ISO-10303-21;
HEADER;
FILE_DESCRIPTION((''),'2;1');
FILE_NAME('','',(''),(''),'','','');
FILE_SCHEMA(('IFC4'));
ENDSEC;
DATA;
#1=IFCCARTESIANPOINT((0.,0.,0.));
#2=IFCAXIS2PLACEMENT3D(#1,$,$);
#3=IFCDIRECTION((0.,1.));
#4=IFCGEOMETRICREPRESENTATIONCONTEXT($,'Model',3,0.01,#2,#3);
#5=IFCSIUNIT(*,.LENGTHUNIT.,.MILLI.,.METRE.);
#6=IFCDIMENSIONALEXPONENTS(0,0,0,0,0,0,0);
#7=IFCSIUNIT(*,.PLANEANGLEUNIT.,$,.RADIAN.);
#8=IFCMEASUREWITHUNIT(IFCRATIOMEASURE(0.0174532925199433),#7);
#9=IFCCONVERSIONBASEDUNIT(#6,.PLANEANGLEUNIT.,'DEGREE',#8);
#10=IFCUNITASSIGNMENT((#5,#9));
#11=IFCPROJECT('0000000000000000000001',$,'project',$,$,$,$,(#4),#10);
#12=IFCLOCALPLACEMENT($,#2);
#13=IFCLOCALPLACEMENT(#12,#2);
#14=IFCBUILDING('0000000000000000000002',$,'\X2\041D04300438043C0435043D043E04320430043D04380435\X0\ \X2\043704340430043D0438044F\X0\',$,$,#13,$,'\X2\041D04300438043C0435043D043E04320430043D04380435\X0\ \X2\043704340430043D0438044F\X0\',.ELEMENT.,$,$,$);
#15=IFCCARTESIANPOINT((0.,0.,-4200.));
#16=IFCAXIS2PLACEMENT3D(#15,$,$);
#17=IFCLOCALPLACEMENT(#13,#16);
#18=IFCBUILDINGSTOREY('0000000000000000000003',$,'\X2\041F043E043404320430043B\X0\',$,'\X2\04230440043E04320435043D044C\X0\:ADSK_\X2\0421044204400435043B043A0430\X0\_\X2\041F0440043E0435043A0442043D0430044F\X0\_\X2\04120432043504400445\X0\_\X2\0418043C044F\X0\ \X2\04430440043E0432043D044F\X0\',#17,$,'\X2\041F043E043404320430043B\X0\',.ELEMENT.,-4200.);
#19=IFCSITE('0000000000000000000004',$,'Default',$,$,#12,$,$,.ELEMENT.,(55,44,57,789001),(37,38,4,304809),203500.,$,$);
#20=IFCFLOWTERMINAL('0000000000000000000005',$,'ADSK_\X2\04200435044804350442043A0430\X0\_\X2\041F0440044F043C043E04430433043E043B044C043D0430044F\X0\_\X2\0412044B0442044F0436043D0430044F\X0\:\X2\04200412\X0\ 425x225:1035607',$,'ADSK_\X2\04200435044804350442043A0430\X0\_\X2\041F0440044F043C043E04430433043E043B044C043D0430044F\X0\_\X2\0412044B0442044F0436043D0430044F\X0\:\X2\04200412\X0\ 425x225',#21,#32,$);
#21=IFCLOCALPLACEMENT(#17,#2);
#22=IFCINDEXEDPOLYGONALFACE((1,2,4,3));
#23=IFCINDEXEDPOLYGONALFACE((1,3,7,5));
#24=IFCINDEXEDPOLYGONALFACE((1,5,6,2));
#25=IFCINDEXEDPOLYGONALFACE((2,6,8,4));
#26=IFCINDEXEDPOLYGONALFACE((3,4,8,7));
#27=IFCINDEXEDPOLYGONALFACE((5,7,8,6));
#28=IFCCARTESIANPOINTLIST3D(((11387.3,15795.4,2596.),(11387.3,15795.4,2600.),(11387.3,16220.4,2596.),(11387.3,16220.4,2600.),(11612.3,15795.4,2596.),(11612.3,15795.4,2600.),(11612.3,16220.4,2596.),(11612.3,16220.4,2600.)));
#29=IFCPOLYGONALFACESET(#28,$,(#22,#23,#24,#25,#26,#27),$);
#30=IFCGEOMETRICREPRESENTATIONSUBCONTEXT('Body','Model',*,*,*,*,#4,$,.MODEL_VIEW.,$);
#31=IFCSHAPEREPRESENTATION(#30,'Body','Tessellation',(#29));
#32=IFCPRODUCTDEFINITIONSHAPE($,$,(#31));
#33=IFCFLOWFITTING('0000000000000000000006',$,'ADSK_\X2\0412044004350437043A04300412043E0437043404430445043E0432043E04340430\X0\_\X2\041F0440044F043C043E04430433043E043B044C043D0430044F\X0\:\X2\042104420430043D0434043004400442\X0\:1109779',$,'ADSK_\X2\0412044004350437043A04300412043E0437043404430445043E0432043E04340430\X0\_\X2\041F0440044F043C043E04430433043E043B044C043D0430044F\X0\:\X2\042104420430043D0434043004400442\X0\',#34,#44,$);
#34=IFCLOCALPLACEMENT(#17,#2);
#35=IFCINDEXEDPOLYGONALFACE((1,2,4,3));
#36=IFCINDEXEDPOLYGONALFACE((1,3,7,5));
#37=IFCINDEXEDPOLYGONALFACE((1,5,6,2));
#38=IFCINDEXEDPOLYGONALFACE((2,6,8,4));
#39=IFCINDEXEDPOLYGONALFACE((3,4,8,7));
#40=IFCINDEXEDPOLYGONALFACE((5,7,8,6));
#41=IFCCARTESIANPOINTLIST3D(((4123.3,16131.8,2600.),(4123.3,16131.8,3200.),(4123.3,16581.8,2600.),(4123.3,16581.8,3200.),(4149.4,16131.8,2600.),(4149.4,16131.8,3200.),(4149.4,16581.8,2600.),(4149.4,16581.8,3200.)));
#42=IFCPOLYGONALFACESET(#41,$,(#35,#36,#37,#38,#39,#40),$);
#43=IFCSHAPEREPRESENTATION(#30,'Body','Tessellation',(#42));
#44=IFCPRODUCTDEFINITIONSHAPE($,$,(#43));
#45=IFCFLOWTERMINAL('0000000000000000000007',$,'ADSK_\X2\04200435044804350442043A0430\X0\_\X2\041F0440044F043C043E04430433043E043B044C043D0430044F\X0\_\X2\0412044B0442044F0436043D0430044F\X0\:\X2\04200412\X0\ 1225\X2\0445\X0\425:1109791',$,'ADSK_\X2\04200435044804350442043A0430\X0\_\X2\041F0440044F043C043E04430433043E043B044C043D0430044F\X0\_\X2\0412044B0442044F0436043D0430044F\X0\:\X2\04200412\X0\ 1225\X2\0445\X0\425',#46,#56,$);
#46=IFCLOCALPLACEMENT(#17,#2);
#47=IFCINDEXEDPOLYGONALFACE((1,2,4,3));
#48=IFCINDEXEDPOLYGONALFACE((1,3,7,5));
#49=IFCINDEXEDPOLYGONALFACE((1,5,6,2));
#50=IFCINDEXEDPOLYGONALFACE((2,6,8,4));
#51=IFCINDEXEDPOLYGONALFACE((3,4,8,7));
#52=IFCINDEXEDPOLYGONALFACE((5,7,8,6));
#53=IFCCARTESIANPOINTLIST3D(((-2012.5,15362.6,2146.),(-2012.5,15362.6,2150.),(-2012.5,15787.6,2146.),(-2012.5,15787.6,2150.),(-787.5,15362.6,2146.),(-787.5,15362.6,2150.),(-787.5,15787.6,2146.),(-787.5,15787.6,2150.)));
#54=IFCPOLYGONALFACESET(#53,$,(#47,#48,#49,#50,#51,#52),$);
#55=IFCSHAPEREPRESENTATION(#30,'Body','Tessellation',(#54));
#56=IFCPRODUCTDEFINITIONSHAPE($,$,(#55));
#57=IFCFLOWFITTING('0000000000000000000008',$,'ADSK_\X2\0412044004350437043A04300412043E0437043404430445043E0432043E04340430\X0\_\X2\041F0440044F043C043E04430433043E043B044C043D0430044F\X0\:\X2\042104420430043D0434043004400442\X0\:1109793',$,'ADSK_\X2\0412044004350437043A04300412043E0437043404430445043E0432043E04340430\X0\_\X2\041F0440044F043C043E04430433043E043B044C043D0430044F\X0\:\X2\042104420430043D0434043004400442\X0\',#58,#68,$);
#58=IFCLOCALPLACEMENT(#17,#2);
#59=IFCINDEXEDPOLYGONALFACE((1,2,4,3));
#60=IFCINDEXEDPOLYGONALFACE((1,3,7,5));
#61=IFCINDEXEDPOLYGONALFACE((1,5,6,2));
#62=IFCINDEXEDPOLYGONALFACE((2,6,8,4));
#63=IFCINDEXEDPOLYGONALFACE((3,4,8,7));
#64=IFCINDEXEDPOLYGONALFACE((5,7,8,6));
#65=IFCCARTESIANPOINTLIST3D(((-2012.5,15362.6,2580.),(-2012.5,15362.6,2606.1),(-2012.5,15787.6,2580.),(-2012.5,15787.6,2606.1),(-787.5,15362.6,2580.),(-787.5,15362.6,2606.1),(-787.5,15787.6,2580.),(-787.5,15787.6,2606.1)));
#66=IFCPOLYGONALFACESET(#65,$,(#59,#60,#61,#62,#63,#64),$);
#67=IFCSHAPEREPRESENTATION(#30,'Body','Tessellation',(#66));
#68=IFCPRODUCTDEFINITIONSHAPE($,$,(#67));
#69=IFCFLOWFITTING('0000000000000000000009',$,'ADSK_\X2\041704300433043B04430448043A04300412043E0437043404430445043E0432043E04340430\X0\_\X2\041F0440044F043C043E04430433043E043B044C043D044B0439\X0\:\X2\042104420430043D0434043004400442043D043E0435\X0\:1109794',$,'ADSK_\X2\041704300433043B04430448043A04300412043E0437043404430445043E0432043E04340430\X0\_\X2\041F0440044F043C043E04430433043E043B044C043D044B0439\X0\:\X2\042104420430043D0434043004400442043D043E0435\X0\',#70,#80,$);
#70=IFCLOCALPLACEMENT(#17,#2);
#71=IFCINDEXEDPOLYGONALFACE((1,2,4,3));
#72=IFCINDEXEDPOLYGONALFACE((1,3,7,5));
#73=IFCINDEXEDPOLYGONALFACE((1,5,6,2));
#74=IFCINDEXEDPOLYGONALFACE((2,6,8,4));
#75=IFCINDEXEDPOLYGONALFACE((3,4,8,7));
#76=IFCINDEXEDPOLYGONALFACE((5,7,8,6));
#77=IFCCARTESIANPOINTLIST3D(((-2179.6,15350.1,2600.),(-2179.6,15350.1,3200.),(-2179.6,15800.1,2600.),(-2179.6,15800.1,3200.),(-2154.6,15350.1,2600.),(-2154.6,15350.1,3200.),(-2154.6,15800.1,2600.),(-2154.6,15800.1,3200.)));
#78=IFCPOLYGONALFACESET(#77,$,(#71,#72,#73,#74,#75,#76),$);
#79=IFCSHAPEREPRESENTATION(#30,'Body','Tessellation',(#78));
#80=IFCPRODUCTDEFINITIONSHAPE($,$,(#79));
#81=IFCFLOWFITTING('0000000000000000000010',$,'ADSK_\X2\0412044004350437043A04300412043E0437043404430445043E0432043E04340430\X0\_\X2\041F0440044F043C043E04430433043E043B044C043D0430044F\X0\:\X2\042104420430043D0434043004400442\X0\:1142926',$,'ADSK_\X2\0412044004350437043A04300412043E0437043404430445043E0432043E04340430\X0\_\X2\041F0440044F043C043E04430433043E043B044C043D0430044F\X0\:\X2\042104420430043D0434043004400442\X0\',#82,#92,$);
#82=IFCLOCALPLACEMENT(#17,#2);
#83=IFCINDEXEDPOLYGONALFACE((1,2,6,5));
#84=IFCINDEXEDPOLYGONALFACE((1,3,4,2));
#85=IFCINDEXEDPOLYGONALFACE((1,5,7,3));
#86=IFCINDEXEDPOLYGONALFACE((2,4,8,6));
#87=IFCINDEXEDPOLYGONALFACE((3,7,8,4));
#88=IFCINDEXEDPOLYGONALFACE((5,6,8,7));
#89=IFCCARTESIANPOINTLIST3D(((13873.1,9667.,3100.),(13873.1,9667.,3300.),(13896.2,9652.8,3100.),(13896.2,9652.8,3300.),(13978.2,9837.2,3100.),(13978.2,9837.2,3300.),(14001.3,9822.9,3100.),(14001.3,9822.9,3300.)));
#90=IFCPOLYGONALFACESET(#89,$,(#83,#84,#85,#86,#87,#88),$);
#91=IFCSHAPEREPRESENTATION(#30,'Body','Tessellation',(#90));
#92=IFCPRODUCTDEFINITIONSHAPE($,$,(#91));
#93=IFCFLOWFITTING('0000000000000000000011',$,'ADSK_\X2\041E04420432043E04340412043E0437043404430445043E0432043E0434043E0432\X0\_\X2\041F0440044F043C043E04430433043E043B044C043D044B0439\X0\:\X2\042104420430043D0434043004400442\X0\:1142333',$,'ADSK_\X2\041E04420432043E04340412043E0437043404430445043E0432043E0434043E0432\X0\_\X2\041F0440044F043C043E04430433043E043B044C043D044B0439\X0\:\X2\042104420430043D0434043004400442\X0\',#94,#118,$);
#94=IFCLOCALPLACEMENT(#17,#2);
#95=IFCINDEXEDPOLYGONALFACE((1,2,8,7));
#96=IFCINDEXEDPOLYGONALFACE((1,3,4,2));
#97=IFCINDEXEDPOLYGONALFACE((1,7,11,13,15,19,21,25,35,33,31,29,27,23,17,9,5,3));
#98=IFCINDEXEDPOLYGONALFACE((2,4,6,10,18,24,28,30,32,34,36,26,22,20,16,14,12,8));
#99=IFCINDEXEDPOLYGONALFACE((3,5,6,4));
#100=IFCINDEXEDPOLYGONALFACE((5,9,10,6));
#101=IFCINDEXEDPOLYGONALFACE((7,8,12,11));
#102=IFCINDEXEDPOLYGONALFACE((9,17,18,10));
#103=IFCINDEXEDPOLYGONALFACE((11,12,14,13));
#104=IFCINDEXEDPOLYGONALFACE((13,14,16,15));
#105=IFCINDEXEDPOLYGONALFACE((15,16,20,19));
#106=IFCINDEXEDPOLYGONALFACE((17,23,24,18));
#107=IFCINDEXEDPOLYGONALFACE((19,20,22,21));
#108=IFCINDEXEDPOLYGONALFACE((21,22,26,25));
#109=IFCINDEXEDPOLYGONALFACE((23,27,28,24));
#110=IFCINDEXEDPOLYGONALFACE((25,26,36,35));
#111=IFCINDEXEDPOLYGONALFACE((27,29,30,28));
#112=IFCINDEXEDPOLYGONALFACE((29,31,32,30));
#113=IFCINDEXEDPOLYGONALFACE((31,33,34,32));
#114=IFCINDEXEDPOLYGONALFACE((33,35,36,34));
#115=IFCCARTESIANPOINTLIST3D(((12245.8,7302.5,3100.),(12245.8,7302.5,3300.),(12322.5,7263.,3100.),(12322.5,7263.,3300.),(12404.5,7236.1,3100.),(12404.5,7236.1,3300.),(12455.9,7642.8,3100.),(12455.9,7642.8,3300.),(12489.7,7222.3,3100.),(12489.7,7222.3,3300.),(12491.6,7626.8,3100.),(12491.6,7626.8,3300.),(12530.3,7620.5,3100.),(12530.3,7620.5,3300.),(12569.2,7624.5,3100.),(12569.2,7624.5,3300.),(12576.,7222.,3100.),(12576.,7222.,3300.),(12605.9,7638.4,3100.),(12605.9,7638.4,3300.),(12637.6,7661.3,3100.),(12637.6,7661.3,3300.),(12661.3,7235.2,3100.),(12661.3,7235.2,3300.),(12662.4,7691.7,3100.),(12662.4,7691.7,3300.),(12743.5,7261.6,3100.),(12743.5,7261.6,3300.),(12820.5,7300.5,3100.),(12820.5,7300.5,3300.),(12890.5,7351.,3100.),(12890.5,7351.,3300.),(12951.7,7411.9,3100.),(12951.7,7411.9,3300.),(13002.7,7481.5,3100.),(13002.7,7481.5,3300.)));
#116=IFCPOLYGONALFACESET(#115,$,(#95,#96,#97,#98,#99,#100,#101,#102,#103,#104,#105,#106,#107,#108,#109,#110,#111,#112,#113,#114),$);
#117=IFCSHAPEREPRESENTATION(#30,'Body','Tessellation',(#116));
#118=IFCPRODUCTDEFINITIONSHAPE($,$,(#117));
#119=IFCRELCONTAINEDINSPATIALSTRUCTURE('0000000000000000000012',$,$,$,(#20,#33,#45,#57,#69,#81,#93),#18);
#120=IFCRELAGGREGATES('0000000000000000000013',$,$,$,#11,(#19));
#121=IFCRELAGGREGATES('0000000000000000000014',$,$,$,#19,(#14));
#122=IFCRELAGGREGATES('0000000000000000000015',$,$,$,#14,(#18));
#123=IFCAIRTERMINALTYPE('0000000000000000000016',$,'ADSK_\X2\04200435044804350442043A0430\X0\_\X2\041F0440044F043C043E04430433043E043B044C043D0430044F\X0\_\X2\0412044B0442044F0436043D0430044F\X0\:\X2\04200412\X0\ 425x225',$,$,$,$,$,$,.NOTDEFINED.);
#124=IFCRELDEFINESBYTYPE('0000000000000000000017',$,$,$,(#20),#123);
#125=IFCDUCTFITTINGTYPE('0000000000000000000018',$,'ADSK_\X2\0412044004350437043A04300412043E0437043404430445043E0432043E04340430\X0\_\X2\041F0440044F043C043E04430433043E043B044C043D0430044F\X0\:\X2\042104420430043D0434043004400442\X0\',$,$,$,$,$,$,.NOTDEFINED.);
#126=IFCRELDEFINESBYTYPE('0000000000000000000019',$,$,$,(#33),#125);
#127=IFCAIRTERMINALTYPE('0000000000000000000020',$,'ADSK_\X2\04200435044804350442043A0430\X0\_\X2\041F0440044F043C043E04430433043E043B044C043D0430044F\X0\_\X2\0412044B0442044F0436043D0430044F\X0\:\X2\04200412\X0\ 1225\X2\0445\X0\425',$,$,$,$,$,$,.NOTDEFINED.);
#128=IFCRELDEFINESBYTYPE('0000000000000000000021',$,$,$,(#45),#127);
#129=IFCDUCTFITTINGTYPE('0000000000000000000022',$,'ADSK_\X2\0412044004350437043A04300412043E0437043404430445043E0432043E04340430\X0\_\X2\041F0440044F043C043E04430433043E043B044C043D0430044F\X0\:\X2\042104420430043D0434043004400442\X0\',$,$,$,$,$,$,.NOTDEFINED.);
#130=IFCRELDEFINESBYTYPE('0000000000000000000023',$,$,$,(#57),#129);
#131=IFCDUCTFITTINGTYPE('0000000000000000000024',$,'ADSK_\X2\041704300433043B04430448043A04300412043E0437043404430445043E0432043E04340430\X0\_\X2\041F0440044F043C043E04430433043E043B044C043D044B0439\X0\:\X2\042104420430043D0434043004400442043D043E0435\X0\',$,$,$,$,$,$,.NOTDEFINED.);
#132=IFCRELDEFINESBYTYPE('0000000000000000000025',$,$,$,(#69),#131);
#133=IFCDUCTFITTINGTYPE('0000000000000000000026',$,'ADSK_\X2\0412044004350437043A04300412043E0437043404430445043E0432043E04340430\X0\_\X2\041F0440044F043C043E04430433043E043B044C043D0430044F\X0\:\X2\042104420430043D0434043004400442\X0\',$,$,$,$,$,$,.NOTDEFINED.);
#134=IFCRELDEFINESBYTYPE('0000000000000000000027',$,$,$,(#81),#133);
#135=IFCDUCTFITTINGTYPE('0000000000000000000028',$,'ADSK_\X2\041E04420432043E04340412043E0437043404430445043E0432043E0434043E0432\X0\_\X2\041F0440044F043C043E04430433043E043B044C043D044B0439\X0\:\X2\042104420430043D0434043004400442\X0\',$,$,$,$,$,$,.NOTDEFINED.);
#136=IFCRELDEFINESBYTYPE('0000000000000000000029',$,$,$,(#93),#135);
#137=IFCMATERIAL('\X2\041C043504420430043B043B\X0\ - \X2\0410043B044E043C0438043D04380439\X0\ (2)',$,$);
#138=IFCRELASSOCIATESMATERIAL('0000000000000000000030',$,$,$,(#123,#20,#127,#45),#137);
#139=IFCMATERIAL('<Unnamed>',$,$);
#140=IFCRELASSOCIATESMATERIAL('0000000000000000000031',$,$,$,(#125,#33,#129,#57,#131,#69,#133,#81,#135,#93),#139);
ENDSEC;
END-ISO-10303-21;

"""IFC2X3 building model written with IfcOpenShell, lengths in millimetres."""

from ifc_helpers import new_model, entity, si_unit, converted_unit, direction, frame, frame_2d, origin, origin_2d_with_axis, place, context, subcontext, project, spatial, polyline, circle_curve, parameter, trimmed, segment, composite_curve, rectangle, outline, extrude, source, transform, mapped, material, type_object, type_shapes, element, save


model = new_model("IFC2X3")

# Units and contexts
model_context = context("Model", 3, precision=0.01, world=origin(), true_north=direction((0.0, 1.0)))
body_context = subcontext(model_context, "Body", "Model", "MODEL_VIEW")
ifc_project = project(units=[si_unit("LENGTHUNIT", "METRE", prefix="MILLI"), converted_unit("PLANEANGLEUNIT", "DEGREE", entity("IfcRatioMeasure", 0.0174532925199433), si_unit("PLANEANGLEUNIT", "RADIAN"), dimensions=[0, 0, 0, 0, 0, 0, 0])], contexts=[model_context])

# Site, building, storey
site_placement = place(None, origin())
site = spatial("IfcSite", under=ifc_project, at=site_placement, Name="Default", CompositionType="ELEMENT", RefLatitude=(55, 44, 57, 789001), RefLongitude=(37, 38, 4, 304809), RefElevation=203500.0)
building_placement = place(site_placement, origin())
building = spatial("IfcBuilding", under=site, at=building_placement, Name="Наименование здания", LongName="Наименование здания", CompositionType="ELEMENT")
storey_placement = place(building_placement, frame((0.0, 0.0, -4200.0)))
storey = spatial("IfcBuildingStorey", under=building, at=storey_placement, Name="Подвал", ObjectType="Уровень:ADSK_Стрелка_Проектная_Вверх_Имя уровня", LongName="Подвал", CompositionType="ELEMENT", Elevation=-4200.0)

# Shared definitions
ifc_material_1 = material(Name="<Unnamed>")

# Flow terminal
ifc_material_2 = material(Name="Металл - Алюминий (2)")
air_terminal_type_1 = type_object("IfcAirTerminalType", Name="ADSK_Решетка_Прямоугольная_Вытяжная:РВ 425x225", PredefinedType="NOTDEFINED", material=ifc_material_2)
shared_shape_1 = source(origin(), body_context, "Body", "SweptSolid", [
    extrude(rectangle(XDim=4.0, YDim=425.0, at=origin_2d_with_axis()), frame((0.0, -2.0, -112.5), z_axis=(0.0, 0.0, 1.0), x_axis=(0.0, 1.0, 0.0)), (0.0, 0.0, 1.0), 225.0),
])
type_shapes(air_terminal_type_1, [shared_shape_1])
flow_terminal_1_placement = place(storey_placement, frame((11499.8, 16007.9, 2600.0), z_axis=(1.0, 0.0, 0.0), x_axis=(0.0, 1.0, 0.0)))
element("IfcFlowTerminal", 1, at=flow_terminal_1_placement, inside=storey, type_object=air_terminal_type_1, material=ifc_material_2, Name="ADSK_Решетка_Прямоугольная_Вытяжная:РВ 425x225:1035607", ObjectType="ADSK_Решетка_Прямоугольная_Вытяжная:РВ 425x225", context=body_context, shape_type="MappedRepresentation", body=[
    mapped(shared_shape_1, transform((0.0, 0.0, 0.0), scale=1.0)),
])

# Flow fitting
duct_fitting_type_1 = type_object("IfcDuctFittingType", Name="ADSK_ВрезкаВоздуховода_Прямоугольная:Стандарт", PredefinedType="NOTDEFINED", material=ifc_material_1)
shared_shape_2 = source(origin(), body_context, "Body", "SweptSolid", [
    extrude(rectangle(XDim=26.1, YDim=600.0, at=origin_2d_with_axis()), frame((7.0, 0.0, -225.0)), (0.0, 0.0, 1.0), 450.0),
])
type_shapes(duct_fitting_type_1, [shared_shape_2])
flow_fitting_1_placement = place(storey_placement, frame((4143.3, 16356.8, 2900.0), z_axis=(0.0, 1.0, 0.0), x_axis=(-1.0, 0.0, 0.0)))
element("IfcFlowFitting", 2, at=flow_fitting_1_placement, inside=storey, type_object=duct_fitting_type_1, material=ifc_material_1, Name="ADSK_ВрезкаВоздуховода_Прямоугольная:Стандарт:1109779", ObjectType="ADSK_ВрезкаВоздуховода_Прямоугольная:Стандарт", context=body_context, shape_type="MappedRepresentation", body=[
    mapped(shared_shape_2, transform((0.0, 0.0, 0.0), scale=1.0)),
])

# Flow terminal
air_terminal_type_2 = type_object("IfcAirTerminalType", Name="ADSK_Решетка_Прямоугольная_Вытяжная:РВ 1225х425", PredefinedType="NOTDEFINED", material=ifc_material_2)
shared_shape_3 = source(origin(), body_context, "Body", "SweptSolid", [
    extrude(rectangle(XDim=4.0, YDim=1225.0, at=origin_2d_with_axis()), frame((0.0, -2.0, -212.5), z_axis=(0.0, 0.0, 1.0), x_axis=(0.0, 1.0, 0.0)), (0.0, 0.0, 1.0), 425.0),
])
type_shapes(air_terminal_type_2, [shared_shape_3])
flow_terminal_2_placement = place(storey_placement, frame((-1400.0, 15575.1, 2150.0), z_axis=(0.0, -1.0, 0.0), x_axis=(1.0, 0.0, 0.0)))
element("IfcFlowTerminal", 3, at=flow_terminal_2_placement, inside=storey, type_object=air_terminal_type_2, material=ifc_material_2, Name="ADSK_Решетка_Прямоугольная_Вытяжная:РВ 1225х425:1109791", ObjectType="ADSK_Решетка_Прямоугольная_Вытяжная:РВ 1225х425", context=body_context, shape_type="MappedRepresentation", body=[
    mapped(shared_shape_3, transform((0.0, 0.0, 0.0), scale=1.0)),
])

# Flow fittings
duct_fitting_type_2 = type_object("IfcDuctFittingType", Name="ADSK_ВрезкаВоздуховода_Прямоугольная:Стандарт", PredefinedType="NOTDEFINED", material=ifc_material_1)
shared_shape_4 = source(origin(), body_context, "Body", "SweptSolid", [
    extrude(rectangle(XDim=26.1, YDim=1225.0, at=origin_2d_with_axis()), frame((7.0, 0.0, -212.5)), (0.0, 0.0, 1.0), 425.0),
])
type_shapes(duct_fitting_type_2, [shared_shape_4])
flow_fitting_2_placement = place(storey_placement, frame((-1400.0, 15575.1, 2600.0), z_axis=(0.0, -1.0, 0.0), x_axis=(0.0, 0.0, -1.0)))
element("IfcFlowFitting", 4, at=flow_fitting_2_placement, inside=storey, type_object=duct_fitting_type_2, material=ifc_material_1, Name="ADSK_ВрезкаВоздуховода_Прямоугольная:Стандарт:1109793", ObjectType="ADSK_ВрезкаВоздуховода_Прямоугольная:Стандарт", context=body_context, shape_type="MappedRepresentation", body=[
    mapped(shared_shape_4, transform((0.0, 0.0, 0.0), scale=1.0)),
])
duct_fitting_type_3 = type_object("IfcDuctFittingType", Name="ADSK_ЗаглушкаВоздуховода_Прямоугольный:Стандартное", PredefinedType="NOTDEFINED", material=ifc_material_1)
shared_shape_5 = source(origin(), body_context, "Body", "SweptSolid", [
    extrude(rectangle(XDim=25.0, YDim=450.0, at=origin_2d_with_axis()), frame((12.5, 0.0, -300.0)), (0.0, 0.0, 1.0), 600.0),
])
type_shapes(duct_fitting_type_3, [shared_shape_5])
flow_fitting_3_placement = place(storey_placement, frame((-2154.6, 15575.1, 2900.0), z_axis=(0.0, 0.0, 1.0), x_axis=(-1.0, 0.0, 0.0)))
element("IfcFlowFitting", 5, at=flow_fitting_3_placement, inside=storey, type_object=duct_fitting_type_3, material=ifc_material_1, Name="ADSK_ЗаглушкаВоздуховода_Прямоугольный:Стандартное:1109794", ObjectType="ADSK_ЗаглушкаВоздуховода_Прямоугольный:Стандартное", context=body_context, shape_type="MappedRepresentation", body=[
    mapped(shared_shape_5, transform((0.0, 0.0, 0.0), scale=1.0)),
])
duct_fitting_type_4 = type_object("IfcDuctFittingType", Name="ADSK_ВрезкаВоздуховода_Прямоугольная:Стандарт", PredefinedType="NOTDEFINED", material=ifc_material_1)
shared_shape_6 = source(origin(), body_context, "Body", "SweptSolid", [
    extrude(rectangle(XDim=200.0, YDim=27.1, at=origin_2d_with_axis()), frame((7.0, 0.0, -100.0), z_axis=(0.0, 0.0, 1.0), x_axis=(0.0, -1.0, 0.0)), (0.0, 0.0, 1.0), 200.0),
])
type_shapes(duct_fitting_type_4, [shared_shape_6])
flow_fitting_4_placement = place(storey_placement, frame((13943.1, 9741.3, 3200.0), z_axis=(0.0, 0.0, -1.0), x_axis=(-0.850783, 0.525517, 0.0)))
element("IfcFlowFitting", 6, at=flow_fitting_4_placement, inside=storey, type_object=duct_fitting_type_4, material=ifc_material_1, Name="ADSK_ВрезкаВоздуховода_Прямоугольная:Стандарт:1142926", ObjectType="ADSK_ВрезкаВоздуховода_Прямоугольная:Стандарт", context=body_context, shape_type="MappedRepresentation", body=[
    mapped(shared_shape_6, transform((0.0, 0.0, 0.0), scale=1.0)),
])
duct_fitting_type_5 = type_object("IfcDuctFittingType", Name="ADSK_ОтводВоздуховодов_Прямоугольный:Стандарт", PredefinedType="NOTDEFINED", material=ifc_material_1)
shared_shape_7 = source(origin(), body_context, "Body", "SweptSolid", [
    extrude(outline(composite_curve([segment(polyline([(-375.0, -175.0), (25.0, -175.0)]), True, "CONTINUOUS"), segment(trimmed(circle_curve(frame_2d((175.0, -175.0), x_axis=(0.0, 1.0)), 150.0), [parameter(0.0)], [parameter(90.0)], True, "PARAMETER"), False, "CONTINUOUS"), segment(polyline([(175.0, -25.0), (175.0, 375.0)]), True, "CONTINUOUS"), segment(trimmed(circle_curve(frame_2d((175.0, -175.0), x_axis=(0.0, 1.0)), 550.0), [parameter(0.0)], [parameter(90.0)], True, "PARAMETER"), True, "CONTINUOUS")], self_intersect=False)), frame((-175.0, 175.0, -100.0), z_axis=(0.0, 0.0, 1.0), x_axis=(-1.0, 0.0, 0.0)), (0.0, 0.0, 1.0), 200.0),
])
type_shapes(duct_fitting_type_5, [shared_shape_7])
flow_fitting_5_placement = place(storey_placement, frame((12648.7, 7288.8, 3200.0), z_axis=(0.0, 0.0, 1.0), x_axis=(0.850888, -0.525347, 0.0)))
element("IfcFlowFitting", 7, at=flow_fitting_5_placement, inside=storey, type_object=duct_fitting_type_5, material=ifc_material_1, Name="ADSK_ОтводВоздуховодов_Прямоугольный:Стандарт:1142333", ObjectType="ADSK_ОтводВоздуховодов_Прямоугольный:Стандарт", context=body_context, shape_type="MappedRepresentation", body=[
    mapped(shared_shape_7, transform((0.0, 0.0, 0.0), scale=1.0)),
])

save(model, "model.ifc")
